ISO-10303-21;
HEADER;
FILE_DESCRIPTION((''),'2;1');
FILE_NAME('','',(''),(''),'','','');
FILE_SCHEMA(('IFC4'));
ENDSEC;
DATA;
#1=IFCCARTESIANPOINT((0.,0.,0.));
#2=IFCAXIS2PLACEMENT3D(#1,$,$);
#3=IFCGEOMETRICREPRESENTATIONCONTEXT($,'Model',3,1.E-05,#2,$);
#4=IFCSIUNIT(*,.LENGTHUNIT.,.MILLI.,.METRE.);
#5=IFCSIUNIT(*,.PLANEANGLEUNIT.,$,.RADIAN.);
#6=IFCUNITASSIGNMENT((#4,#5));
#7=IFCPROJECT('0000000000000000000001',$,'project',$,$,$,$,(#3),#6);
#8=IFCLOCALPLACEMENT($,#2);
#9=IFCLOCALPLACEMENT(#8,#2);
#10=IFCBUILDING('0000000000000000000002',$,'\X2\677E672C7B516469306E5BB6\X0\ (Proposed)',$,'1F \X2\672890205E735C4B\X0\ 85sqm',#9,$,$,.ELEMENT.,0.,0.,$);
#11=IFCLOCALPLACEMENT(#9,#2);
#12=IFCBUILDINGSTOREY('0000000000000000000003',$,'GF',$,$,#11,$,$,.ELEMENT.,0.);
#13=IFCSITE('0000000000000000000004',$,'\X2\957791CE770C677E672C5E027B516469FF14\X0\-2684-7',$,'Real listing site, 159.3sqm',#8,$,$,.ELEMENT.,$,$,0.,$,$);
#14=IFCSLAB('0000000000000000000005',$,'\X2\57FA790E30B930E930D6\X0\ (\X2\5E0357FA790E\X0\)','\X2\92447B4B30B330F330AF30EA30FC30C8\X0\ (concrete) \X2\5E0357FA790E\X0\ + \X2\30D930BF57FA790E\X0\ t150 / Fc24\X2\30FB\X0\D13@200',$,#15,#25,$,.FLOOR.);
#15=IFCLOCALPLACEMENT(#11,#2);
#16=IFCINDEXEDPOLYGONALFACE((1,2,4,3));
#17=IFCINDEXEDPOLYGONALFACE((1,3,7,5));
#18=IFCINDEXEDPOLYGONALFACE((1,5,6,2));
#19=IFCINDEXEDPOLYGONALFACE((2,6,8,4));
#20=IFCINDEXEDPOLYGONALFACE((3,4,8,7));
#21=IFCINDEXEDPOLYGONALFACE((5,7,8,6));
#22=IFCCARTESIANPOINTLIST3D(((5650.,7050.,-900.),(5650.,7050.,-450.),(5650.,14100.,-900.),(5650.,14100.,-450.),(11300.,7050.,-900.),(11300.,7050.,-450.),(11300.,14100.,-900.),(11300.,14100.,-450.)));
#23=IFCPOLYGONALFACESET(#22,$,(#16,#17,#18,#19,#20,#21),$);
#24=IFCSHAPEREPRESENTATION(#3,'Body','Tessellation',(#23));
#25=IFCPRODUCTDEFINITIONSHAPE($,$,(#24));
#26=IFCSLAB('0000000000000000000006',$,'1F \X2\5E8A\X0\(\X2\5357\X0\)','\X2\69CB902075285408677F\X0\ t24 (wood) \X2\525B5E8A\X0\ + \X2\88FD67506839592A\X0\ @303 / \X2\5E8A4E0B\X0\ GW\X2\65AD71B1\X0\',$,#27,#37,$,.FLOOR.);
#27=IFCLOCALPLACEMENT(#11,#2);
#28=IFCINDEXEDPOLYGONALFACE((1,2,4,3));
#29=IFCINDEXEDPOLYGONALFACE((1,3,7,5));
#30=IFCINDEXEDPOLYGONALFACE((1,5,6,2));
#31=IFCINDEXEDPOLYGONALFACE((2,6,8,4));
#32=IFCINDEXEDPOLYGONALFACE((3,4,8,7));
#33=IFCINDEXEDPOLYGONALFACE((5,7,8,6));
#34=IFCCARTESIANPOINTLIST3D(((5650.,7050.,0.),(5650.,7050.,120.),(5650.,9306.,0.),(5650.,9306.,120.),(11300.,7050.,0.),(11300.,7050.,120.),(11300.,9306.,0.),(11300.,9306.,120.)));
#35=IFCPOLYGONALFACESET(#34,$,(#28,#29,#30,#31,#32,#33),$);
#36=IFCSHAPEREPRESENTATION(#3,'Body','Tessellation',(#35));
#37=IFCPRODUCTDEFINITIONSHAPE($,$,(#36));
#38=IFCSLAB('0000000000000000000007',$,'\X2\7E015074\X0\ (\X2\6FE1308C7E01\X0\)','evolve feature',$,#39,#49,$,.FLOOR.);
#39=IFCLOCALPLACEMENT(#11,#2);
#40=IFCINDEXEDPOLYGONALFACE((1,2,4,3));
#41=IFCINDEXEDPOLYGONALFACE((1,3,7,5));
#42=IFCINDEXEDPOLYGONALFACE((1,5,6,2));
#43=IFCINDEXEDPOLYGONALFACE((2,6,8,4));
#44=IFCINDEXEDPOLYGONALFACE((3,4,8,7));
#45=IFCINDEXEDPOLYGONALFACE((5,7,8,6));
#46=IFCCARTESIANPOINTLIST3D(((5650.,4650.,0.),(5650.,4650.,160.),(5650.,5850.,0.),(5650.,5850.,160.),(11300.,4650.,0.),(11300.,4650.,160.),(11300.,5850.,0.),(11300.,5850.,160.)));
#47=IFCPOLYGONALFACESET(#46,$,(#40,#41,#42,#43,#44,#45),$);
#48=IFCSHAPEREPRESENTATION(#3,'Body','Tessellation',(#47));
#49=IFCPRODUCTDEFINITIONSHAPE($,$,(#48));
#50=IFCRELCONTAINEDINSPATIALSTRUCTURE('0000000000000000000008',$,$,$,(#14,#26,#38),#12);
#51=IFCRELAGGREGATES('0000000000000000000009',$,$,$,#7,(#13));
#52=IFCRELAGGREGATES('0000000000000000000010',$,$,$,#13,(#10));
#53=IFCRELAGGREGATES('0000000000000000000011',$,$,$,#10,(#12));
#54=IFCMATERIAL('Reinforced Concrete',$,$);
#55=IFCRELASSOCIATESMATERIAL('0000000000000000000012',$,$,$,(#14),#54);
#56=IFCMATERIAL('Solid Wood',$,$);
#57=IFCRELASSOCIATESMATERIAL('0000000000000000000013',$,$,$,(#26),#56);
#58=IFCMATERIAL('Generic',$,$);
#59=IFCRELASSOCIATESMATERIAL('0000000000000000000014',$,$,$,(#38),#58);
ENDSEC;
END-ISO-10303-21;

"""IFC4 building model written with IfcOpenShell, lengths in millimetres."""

from ifc_helpers import new_model, si_unit, frame, frame_2d, origin, place, context, project, spatial, rectangle, extrude, material, element, save


model = new_model("IFC4")

# Units and contexts
model_context = context("Model", 3, precision=1e-05, world=origin())
ifc_project = project(units=[si_unit("LENGTHUNIT", "METRE", prefix="MILLI"), si_unit("PLANEANGLEUNIT", "RADIAN")], contexts=[model_context])

# Site, building, storey
site_placement = place(None, origin())
site = spatial("IfcSite", under=ifc_project, at=site_placement, Name="長野県松本市筑摩４-2684-7", ObjectType="Real listing site, 159.3sqm", CompositionType="ELEMENT", RefElevation=0.0)
building_placement = place(site_placement, origin())
building = spatial("IfcBuilding", under=site, at=building_placement, Name="松本筑摩の家 (Proposed)", ObjectType="1F 木造平屋 85sqm", CompositionType="ELEMENT", ElevationOfRefHeight=0.0, ElevationOfTerrain=0.0)
storey_placement = place(building_placement, origin())
storey = spatial("IfcBuildingStorey", under=building, at=storey_placement, Name="GF", CompositionType="ELEMENT", Elevation=0.0)

# Slabs
ifc_material_1 = material(Name="Reinforced Concrete")
slab_1_placement = place(storey_placement, frame((2825.0, 3525.0, -450.0)))
element("IfcSlab", 1, at=slab_1_placement, inside=storey, material=ifc_material_1, Name="基礎スラブ (布基礎)", Description="鉄筋コンクリート (concrete) 布基礎 + ベタ基礎 t150 / Fc24・D13@200", PredefinedType="FLOOR", context=model_context, shape_type="SweptSolid", body=[
    extrude(rectangle(XDim=5650.0, YDim=7050.0, at=frame_2d((2825.0, 3525.0))), frame((2825.0, 3525.0, -450.0)), (0.0, 0.0, 1.0), 450.0),
])
ifc_material_2 = material(Name="Solid Wood")
slab_2_placement = place(storey_placement, frame((2825.0, 3525.0, 0.0)))
element("IfcSlab", 2, at=slab_2_placement, inside=storey, material=ifc_material_2, Name="1F 床(南)", Description="構造用合板 t24 (wood) 剛床 + 製材根太 @303 / 床下 GW断熱", PredefinedType="FLOOR", context=model_context, shape_type="SweptSolid", body=[
    extrude(rectangle(XDim=5650.0, YDim=2256.0, at=frame_2d((2825.0, 1128.0))), frame((2825.0, 3525.0, 0.0)), (0.0, 0.0, 1.0), 120.0),
])
ifc_material_3 = material(Name="Generic")
slab_3_placement = place(storey_placement, frame((2825.0, 2325.0, 0.0)))
element("IfcSlab", 3, at=slab_3_placement, inside=storey, material=ifc_material_3, Name="縁側 (濡れ縁)", Description="evolve feature", PredefinedType="FLOOR", context=model_context, shape_type="SweptSolid", body=[
    extrude(rectangle(XDim=5650.0, YDim=1200.0, at=frame_2d((2825.0, 600.0))), frame((2825.0, 2325.0, 0.0)), (0.0, 0.0, 1.0), 160.0),
])

save(model, "model.ifc")
